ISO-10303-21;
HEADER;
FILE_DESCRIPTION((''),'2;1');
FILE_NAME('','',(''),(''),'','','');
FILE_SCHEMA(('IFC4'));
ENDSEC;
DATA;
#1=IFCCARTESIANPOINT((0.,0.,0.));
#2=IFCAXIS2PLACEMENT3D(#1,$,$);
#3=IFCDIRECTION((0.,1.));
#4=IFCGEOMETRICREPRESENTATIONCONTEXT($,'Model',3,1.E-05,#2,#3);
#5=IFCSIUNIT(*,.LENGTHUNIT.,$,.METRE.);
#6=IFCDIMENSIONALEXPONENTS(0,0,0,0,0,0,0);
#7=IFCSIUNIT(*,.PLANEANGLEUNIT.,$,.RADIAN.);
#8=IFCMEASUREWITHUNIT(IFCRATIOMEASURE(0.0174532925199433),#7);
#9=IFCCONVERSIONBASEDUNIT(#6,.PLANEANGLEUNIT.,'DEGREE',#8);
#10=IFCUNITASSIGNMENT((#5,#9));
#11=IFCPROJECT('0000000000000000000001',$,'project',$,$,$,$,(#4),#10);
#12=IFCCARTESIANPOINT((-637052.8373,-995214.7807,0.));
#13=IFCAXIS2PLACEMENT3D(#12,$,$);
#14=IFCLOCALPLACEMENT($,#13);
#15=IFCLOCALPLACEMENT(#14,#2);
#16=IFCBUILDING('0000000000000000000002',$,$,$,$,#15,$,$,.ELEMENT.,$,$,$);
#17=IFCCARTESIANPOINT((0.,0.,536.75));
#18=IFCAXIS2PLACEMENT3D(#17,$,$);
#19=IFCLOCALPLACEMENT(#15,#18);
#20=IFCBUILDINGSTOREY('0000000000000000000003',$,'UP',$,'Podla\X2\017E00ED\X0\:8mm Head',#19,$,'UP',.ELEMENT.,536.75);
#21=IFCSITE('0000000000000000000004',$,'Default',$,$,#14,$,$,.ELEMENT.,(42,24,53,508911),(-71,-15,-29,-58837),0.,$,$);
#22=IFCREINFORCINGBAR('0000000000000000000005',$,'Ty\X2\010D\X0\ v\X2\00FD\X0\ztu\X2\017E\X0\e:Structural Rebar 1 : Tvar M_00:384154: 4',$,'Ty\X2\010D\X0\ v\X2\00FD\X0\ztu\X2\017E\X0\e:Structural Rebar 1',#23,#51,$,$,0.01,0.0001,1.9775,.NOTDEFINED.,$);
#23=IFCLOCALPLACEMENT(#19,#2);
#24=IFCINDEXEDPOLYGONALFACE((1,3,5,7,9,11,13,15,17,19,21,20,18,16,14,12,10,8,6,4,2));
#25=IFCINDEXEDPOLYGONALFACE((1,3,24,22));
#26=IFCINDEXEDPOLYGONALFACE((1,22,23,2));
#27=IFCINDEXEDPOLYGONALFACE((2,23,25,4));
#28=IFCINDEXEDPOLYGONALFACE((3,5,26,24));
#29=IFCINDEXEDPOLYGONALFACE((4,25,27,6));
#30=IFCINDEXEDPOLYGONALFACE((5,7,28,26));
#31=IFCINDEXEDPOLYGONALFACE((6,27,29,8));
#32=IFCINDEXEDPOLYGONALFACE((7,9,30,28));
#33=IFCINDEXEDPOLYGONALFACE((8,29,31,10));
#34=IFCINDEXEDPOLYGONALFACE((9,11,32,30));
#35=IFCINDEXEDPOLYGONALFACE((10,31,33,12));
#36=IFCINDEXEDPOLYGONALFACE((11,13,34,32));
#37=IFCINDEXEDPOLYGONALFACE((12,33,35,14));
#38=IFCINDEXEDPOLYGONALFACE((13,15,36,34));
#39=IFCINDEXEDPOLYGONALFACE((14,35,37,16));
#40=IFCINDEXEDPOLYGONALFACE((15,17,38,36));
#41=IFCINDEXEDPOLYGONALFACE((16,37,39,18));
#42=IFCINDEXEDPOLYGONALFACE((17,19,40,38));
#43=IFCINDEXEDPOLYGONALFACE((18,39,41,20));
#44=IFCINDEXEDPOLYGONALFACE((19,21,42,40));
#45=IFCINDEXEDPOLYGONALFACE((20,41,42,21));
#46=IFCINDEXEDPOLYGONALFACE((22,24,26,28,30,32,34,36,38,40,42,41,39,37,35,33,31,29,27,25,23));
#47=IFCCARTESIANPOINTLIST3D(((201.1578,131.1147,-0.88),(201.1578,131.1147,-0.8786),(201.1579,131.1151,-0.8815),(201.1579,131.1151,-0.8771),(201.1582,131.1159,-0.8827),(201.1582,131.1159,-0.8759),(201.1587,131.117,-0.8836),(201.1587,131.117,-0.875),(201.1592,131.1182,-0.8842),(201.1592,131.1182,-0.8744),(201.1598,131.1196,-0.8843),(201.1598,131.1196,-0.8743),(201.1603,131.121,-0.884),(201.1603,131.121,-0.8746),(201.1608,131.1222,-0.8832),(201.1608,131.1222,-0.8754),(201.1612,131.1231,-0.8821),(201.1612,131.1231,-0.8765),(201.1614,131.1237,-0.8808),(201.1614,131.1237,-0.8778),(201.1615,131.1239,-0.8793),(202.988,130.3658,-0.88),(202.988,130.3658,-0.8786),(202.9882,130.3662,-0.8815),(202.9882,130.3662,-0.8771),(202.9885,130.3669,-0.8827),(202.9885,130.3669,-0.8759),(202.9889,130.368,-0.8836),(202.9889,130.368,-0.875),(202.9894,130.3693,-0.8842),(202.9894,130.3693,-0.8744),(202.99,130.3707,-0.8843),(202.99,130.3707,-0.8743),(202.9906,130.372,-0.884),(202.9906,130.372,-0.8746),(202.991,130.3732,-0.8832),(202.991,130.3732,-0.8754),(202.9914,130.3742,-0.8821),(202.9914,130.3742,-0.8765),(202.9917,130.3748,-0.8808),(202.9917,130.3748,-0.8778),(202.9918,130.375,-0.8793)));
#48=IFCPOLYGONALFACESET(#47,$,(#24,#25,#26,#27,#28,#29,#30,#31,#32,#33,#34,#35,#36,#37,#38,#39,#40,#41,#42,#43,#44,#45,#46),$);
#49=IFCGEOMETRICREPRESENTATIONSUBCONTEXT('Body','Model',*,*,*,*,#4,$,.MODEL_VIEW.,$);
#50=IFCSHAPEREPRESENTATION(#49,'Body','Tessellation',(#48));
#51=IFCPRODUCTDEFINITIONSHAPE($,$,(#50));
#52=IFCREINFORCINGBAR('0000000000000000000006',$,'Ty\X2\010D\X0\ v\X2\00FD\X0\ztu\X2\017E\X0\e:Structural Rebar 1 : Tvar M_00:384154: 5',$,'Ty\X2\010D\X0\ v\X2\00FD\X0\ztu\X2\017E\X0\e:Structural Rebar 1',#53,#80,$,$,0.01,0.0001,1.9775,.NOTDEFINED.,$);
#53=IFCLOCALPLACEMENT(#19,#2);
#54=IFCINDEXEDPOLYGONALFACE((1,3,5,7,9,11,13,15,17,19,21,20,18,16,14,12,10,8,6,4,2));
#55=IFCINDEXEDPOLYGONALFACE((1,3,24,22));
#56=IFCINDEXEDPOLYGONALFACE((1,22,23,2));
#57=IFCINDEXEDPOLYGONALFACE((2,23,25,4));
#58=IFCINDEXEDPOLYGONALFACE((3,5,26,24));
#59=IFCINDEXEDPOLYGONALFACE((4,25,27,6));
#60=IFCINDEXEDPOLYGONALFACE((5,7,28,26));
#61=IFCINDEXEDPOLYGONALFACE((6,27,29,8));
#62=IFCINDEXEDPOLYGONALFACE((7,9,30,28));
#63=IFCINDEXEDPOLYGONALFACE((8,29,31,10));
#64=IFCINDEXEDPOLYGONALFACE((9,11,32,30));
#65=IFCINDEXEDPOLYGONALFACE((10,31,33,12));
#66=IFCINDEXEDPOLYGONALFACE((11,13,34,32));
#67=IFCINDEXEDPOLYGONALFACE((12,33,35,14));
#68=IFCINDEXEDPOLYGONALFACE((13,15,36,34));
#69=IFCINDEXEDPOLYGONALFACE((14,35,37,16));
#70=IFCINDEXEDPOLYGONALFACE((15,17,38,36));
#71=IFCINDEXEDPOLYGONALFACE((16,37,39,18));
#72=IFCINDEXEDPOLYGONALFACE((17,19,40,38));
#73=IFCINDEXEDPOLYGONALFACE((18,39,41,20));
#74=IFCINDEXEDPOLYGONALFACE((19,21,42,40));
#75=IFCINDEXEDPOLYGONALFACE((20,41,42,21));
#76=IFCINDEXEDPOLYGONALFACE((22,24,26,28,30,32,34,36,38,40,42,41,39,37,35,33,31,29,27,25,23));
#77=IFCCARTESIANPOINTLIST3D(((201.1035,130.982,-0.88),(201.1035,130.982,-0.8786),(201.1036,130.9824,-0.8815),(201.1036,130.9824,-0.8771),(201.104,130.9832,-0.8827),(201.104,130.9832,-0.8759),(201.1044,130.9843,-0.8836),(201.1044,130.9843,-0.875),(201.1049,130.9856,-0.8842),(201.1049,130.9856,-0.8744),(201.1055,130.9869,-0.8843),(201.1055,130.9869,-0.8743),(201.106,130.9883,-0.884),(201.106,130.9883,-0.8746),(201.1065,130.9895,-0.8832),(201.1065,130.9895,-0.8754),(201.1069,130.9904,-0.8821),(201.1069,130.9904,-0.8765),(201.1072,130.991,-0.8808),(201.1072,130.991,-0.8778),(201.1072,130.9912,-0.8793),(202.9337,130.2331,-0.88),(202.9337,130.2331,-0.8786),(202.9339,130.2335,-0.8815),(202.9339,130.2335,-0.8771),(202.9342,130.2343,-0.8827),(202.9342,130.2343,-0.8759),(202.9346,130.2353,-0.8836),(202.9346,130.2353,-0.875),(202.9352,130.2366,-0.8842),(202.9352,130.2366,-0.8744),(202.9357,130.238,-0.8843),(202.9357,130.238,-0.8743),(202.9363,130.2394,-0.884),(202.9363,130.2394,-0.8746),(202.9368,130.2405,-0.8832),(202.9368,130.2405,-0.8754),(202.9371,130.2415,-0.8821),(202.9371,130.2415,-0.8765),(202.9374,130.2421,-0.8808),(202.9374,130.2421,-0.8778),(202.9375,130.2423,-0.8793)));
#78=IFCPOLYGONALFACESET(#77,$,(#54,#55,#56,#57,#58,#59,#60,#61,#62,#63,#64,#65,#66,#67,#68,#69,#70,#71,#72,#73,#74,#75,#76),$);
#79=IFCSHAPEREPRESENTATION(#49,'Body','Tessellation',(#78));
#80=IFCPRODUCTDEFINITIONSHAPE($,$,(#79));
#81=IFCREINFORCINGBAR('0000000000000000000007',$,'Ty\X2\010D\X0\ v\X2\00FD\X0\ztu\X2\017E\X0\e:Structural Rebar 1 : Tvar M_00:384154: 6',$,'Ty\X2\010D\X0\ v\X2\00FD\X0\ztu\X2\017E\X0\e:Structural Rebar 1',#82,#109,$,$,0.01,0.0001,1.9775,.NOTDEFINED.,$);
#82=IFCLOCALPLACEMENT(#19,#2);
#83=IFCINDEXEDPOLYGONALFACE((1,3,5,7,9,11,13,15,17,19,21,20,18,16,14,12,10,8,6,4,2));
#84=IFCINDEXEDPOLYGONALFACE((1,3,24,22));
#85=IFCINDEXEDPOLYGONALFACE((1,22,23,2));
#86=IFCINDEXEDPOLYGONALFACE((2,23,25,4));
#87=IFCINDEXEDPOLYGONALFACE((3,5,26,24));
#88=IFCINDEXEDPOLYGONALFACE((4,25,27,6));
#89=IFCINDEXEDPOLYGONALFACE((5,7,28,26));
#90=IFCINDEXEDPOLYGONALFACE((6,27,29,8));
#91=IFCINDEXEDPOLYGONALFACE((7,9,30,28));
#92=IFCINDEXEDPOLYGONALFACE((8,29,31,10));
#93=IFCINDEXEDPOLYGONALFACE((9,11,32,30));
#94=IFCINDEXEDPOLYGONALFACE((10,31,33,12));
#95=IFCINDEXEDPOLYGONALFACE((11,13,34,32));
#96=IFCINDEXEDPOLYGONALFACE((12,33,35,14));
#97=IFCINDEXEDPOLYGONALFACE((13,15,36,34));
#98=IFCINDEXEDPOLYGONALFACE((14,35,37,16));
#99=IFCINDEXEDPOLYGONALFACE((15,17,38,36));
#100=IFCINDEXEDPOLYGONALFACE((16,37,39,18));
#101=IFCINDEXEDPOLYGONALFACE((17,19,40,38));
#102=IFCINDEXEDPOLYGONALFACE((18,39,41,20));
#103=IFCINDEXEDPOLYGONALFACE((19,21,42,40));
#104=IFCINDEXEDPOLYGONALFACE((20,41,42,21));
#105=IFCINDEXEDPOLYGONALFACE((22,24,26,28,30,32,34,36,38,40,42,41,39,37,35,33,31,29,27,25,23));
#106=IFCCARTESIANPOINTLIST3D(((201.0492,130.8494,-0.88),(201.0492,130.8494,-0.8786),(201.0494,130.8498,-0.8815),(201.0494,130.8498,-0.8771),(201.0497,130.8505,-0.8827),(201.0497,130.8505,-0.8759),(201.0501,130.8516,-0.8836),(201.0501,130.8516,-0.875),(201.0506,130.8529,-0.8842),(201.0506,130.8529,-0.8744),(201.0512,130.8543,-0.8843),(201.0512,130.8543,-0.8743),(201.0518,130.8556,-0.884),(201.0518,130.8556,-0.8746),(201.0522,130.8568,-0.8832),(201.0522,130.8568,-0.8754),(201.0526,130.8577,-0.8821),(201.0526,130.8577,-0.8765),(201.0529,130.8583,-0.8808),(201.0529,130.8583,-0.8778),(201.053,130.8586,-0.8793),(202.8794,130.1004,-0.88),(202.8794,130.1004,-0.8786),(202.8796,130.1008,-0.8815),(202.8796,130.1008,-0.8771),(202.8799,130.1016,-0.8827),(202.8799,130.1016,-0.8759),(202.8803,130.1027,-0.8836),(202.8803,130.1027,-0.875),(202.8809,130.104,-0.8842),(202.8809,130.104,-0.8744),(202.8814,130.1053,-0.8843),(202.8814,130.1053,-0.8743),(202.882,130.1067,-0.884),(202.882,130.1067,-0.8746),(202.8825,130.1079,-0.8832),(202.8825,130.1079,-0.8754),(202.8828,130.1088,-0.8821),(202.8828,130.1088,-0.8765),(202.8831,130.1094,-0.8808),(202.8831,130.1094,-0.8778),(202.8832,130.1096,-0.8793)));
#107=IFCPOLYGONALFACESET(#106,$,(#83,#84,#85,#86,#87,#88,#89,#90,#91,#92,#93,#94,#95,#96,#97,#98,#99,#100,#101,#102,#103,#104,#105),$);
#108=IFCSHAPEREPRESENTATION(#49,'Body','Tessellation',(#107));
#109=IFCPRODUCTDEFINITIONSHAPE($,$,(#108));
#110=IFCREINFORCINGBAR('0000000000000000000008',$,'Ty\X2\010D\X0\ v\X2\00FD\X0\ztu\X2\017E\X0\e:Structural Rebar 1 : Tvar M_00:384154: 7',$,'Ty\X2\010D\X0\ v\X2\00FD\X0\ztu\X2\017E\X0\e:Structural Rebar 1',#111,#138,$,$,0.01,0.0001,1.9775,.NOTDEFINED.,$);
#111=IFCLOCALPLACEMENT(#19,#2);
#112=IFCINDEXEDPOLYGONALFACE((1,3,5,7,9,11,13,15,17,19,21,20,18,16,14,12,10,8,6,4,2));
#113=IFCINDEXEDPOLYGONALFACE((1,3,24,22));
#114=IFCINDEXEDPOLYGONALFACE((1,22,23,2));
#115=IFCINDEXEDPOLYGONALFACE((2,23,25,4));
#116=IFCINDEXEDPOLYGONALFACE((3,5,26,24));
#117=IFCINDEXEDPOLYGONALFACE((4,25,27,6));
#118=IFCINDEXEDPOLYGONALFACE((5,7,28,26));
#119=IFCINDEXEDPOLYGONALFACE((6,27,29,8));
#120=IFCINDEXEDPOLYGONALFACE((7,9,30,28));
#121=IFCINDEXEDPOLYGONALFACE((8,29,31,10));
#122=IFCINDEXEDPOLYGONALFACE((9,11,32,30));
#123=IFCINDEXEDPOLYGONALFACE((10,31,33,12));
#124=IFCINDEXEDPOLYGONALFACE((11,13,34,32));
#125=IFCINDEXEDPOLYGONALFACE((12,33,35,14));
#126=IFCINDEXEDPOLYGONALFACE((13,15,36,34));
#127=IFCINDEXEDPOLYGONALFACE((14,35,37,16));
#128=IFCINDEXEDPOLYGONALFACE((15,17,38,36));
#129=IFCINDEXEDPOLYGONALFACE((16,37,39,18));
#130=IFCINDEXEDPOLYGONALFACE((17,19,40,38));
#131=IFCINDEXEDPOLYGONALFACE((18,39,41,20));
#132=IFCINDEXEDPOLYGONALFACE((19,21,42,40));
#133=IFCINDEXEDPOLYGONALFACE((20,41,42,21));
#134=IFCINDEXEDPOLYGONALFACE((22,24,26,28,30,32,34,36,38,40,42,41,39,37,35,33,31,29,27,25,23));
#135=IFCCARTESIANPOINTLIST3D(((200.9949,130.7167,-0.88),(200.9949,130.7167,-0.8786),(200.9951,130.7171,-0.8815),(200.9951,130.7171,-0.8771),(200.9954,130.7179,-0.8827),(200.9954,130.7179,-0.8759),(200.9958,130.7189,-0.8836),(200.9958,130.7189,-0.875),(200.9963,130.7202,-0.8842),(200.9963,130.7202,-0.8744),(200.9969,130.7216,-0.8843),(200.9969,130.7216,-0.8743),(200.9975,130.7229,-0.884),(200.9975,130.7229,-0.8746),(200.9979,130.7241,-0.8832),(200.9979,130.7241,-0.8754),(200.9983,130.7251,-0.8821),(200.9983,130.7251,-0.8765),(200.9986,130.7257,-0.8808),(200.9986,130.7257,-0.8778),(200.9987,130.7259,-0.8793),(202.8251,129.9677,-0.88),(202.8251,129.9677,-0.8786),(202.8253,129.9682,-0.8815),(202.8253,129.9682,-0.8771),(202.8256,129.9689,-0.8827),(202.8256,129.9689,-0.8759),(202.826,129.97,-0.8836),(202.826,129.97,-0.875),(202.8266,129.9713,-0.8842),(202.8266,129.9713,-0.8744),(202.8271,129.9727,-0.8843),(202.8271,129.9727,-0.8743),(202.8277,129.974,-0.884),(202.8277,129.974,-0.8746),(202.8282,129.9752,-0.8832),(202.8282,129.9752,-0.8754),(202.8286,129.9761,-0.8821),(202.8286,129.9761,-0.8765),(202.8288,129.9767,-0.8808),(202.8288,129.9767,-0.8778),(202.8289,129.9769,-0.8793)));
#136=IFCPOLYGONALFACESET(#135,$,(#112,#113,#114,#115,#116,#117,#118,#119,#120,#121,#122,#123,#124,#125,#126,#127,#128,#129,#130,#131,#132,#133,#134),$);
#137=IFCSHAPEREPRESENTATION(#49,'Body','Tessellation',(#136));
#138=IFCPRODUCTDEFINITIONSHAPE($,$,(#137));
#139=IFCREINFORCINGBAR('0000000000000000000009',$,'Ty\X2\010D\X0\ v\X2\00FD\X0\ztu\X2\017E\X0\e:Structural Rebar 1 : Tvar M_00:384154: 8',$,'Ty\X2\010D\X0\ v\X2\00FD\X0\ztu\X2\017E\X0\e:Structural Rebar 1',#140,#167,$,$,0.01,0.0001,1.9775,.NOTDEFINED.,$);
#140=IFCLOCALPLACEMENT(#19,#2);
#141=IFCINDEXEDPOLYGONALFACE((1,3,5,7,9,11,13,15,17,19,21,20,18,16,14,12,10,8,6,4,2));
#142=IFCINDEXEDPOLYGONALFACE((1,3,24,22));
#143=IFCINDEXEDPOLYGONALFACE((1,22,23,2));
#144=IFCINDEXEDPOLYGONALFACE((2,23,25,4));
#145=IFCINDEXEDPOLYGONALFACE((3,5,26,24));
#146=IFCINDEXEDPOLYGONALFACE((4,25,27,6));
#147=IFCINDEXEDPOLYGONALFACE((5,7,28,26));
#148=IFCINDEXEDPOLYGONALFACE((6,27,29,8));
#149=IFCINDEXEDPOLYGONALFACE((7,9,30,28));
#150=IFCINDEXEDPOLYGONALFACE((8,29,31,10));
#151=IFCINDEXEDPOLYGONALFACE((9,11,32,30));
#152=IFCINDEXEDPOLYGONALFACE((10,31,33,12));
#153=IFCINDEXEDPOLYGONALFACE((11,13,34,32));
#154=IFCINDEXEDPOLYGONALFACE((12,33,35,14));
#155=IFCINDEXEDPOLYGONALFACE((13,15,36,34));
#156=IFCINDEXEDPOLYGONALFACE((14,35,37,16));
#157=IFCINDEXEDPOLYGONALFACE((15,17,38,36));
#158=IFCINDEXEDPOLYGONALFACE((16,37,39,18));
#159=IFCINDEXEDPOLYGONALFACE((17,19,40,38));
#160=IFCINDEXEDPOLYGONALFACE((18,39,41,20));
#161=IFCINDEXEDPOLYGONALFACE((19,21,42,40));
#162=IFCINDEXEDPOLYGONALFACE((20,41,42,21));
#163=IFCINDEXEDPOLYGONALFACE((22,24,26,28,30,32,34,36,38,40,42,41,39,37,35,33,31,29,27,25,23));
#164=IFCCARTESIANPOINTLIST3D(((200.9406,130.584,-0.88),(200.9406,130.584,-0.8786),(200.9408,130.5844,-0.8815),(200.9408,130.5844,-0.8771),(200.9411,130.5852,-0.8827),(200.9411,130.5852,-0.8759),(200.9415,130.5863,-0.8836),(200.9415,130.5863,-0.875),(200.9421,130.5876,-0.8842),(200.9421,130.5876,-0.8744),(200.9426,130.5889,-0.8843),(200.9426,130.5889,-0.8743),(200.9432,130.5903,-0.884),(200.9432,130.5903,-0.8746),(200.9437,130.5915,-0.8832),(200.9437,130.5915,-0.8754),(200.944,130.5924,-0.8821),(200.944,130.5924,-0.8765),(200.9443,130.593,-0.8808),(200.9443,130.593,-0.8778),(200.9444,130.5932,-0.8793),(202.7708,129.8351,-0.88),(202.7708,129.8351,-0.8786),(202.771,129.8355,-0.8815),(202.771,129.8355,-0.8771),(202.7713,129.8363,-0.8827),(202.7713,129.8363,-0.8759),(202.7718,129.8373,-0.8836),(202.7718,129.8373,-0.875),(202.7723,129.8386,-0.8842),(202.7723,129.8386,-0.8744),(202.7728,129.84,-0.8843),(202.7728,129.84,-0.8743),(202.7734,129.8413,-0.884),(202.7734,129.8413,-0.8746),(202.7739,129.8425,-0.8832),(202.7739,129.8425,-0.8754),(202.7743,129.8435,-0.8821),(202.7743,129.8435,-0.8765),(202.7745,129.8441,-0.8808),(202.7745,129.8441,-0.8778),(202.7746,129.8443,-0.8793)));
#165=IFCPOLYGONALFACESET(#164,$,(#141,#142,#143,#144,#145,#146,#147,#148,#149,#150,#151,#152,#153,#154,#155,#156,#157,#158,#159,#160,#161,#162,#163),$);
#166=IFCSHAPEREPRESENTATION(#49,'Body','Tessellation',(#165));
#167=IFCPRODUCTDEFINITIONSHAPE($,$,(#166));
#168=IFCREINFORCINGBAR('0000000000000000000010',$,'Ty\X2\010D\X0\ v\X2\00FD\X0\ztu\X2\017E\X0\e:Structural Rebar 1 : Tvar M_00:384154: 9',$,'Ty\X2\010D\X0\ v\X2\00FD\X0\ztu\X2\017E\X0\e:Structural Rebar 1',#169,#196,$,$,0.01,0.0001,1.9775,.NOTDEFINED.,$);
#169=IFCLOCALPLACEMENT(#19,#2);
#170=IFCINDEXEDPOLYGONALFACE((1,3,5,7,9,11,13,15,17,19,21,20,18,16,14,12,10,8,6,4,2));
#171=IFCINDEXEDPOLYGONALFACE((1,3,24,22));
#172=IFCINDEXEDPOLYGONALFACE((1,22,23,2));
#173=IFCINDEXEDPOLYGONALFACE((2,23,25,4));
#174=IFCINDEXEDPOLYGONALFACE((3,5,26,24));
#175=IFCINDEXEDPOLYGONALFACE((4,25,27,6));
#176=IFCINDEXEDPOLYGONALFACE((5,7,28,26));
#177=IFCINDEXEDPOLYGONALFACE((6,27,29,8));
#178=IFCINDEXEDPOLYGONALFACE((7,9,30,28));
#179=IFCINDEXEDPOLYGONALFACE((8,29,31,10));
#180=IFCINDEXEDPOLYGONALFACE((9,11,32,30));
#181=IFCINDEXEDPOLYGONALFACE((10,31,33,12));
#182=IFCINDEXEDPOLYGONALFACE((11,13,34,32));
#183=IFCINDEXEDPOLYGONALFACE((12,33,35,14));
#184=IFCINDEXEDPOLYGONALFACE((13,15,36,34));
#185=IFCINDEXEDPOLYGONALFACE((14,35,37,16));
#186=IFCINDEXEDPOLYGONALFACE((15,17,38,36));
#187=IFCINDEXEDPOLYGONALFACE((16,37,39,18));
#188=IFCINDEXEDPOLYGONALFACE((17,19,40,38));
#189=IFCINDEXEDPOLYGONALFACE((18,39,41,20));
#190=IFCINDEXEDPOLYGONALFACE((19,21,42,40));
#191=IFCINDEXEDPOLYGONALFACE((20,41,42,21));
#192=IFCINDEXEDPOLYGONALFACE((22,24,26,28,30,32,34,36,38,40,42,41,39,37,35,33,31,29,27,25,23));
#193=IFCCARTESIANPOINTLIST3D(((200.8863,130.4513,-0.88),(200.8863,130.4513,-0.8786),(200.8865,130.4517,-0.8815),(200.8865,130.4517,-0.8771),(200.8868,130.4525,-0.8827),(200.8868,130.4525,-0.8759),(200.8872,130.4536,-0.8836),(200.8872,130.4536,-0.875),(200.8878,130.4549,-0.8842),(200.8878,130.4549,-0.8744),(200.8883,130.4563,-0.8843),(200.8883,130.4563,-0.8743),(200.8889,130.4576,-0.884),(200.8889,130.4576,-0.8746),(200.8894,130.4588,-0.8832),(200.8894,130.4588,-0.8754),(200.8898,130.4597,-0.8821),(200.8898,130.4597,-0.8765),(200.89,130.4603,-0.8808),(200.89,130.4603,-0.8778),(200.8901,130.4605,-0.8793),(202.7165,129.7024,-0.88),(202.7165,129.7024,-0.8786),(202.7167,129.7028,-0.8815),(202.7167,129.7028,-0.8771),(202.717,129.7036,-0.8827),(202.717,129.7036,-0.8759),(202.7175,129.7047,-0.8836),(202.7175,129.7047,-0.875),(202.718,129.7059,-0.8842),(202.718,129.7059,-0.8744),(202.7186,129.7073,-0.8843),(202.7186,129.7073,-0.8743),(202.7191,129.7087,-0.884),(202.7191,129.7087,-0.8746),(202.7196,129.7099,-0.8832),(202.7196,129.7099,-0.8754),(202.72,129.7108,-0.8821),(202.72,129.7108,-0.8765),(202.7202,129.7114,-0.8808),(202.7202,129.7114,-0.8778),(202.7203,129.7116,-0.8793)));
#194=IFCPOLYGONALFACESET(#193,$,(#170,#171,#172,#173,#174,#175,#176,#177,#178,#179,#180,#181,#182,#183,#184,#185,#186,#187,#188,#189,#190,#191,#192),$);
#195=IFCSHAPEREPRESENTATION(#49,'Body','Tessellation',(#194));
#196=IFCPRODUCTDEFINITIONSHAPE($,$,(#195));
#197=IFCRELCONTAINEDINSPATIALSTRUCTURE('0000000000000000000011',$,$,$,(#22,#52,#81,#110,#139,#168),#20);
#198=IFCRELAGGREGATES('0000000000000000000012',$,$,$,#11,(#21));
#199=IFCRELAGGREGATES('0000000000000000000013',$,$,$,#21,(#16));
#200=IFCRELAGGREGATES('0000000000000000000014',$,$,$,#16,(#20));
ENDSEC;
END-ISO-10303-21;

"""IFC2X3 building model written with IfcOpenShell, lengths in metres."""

from ifc_helpers import new_model, entity, si_unit, converted_unit, direction, frame, origin, place, context, subcontext, project, spatial, element, save


model = new_model("IFC2X3")

# Units and contexts
model_context = context("Model", 3, precision=1e-05, world=origin(), true_north=direction((0.0, 1.0)))
body_context = subcontext(model_context, "Body", "Model", "MODEL_VIEW")
ifc_project = project(units=[si_unit("LENGTHUNIT", "METRE"), converted_unit("PLANEANGLEUNIT", "DEGREE", entity("IfcRatioMeasure", 0.0174532925199433), si_unit("PLANEANGLEUNIT", "RADIAN"), dimensions=[0, 0, 0, 0, 0, 0, 0])], contexts=[model_context])

# Site, building, storey
site_placement = place(None, frame((-637052.8373, -995214.7807, 0.0)))
site = spatial("IfcSite", under=ifc_project, at=site_placement, Name="Default", CompositionType="ELEMENT", RefLatitude=(42, 24, 53, 508911), RefLongitude=(-71, -15, -29, -58837), RefElevation=0.0)
building_placement = place(site_placement, origin())
building = spatial("IfcBuilding", under=site, at=building_placement, CompositionType="ELEMENT")
storey_placement = place(building_placement, frame((0.0, 0.0, 536.75)))
storey = spatial("IfcBuildingStorey", under=building, at=storey_placement, Name="UP", ObjectType="Podlaží:8mm Head", LongName="UP", CompositionType="ELEMENT", Elevation=536.75)

# Reinforcing bars
reinforcing_bar_1_placement = place(storey_placement, origin())
element("IfcReinforcingBar", 1, at=reinforcing_bar_1_placement, inside=storey, Name="Tyč výztuže:Structural Rebar 1 : Tvar M_00:384154: 4", ObjectType="Tyč výztuže:Structural Rebar 1", BarLength=1.9775, BarRole="NOTDEFINED", CrossSectionArea=0.0001, NominalDiameter=0.01, context=body_context, shape_type="AdvancedSweptSolid", body=[
    entity("IfcSweptDiskSolid", entity("IfcCompositeCurve", [entity("IfcCompositeCurveSegment", "CONTINUOUS", True, entity("IfcPolyline", [entity("IfcCartesianPoint", [-202.9899, -130.3703, 0.8793]), entity("IfcCartesianPoint", [-201.1596, -131.1193, 0.8793])]))], False), 0.005, None, 0.0, 1.0),
])
reinforcing_bar_2_placement = place(storey_placement, origin())
element("IfcReinforcingBar", 2, at=reinforcing_bar_2_placement, inside=storey, Name="Tyč výztuže:Structural Rebar 1 : Tvar M_00:384154: 5", ObjectType="Tyč výztuže:Structural Rebar 1", BarLength=1.9775, BarRole="NOTDEFINED", CrossSectionArea=0.0001, NominalDiameter=0.01, context=body_context, shape_type="AdvancedSweptSolid", body=[
    entity("IfcSweptDiskSolid", entity("IfcCompositeCurve", [entity("IfcCompositeCurveSegment", "CONTINUOUS", True, entity("IfcPolyline", [entity("IfcCartesianPoint", [-202.9356, -130.2377, 0.8793]), entity("IfcCartesianPoint", [-201.1053, -130.9866, 0.8793])]))], False), 0.005, None, 0.0, 1.0),
])
reinforcing_bar_3_placement = place(storey_placement, origin())
element("IfcReinforcingBar", 3, at=reinforcing_bar_3_placement, inside=storey, Name="Tyč výztuže:Structural Rebar 1 : Tvar M_00:384154: 6", ObjectType="Tyč výztuže:Structural Rebar 1", BarLength=1.9775, BarRole="NOTDEFINED", CrossSectionArea=0.0001, NominalDiameter=0.01, context=body_context, shape_type="AdvancedSweptSolid", body=[
    entity("IfcSweptDiskSolid", entity("IfcCompositeCurve", [entity("IfcCompositeCurveSegment", "CONTINUOUS", True, entity("IfcPolyline", [entity("IfcCartesianPoint", [-202.8813, -130.105, 0.8793]), entity("IfcCartesianPoint", [-201.0511, -130.8539, 0.8793])]))], False), 0.005, None, 0.0, 1.0),
])
reinforcing_bar_4_placement = place(storey_placement, origin())
element("IfcReinforcingBar", 4, at=reinforcing_bar_4_placement, inside=storey, Name="Tyč výztuže:Structural Rebar 1 : Tvar M_00:384154: 7", ObjectType="Tyč výztuže:Structural Rebar 1", BarLength=1.9775, BarRole="NOTDEFINED", CrossSectionArea=0.0001, NominalDiameter=0.01, context=body_context, shape_type="AdvancedSweptSolid", body=[
    entity("IfcSweptDiskSolid", entity("IfcCompositeCurve", [entity("IfcCompositeCurveSegment", "CONTINUOUS", True, entity("IfcPolyline", [entity("IfcCartesianPoint", [-202.827, -129.9723, 0.8793]), entity("IfcCartesianPoint", [-200.9968, -130.7213, 0.8793])]))], False), 0.005, None, 0.0, 1.0),
])
reinforcing_bar_5_placement = place(storey_placement, origin())
element("IfcReinforcingBar", 5, at=reinforcing_bar_5_placement, inside=storey, Name="Tyč výztuže:Structural Rebar 1 : Tvar M_00:384154: 8", ObjectType="Tyč výztuže:Structural Rebar 1", BarLength=1.9775, BarRole="NOTDEFINED", CrossSectionArea=0.0001, NominalDiameter=0.01, context=body_context, shape_type="AdvancedSweptSolid", body=[
    entity("IfcSweptDiskSolid", entity("IfcCompositeCurve", [entity("IfcCompositeCurveSegment", "CONTINUOUS", True, entity("IfcPolyline", [entity("IfcCartesianPoint", [-202.7727, -129.8396, 0.8793]), entity("IfcCartesianPoint", [-200.9425, -130.5886, 0.8793])]))], False), 0.005, None, 0.0, 1.0),
])
reinforcing_bar_6_placement = place(storey_placement, origin())
element("IfcReinforcingBar", 6, at=reinforcing_bar_6_placement, inside=storey, Name="Tyč výztuže:Structural Rebar 1 : Tvar M_00:384154: 9", ObjectType="Tyč výztuže:Structural Rebar 1", BarLength=1.9775, BarRole="NOTDEFINED", CrossSectionArea=0.0001, NominalDiameter=0.01, context=body_context, shape_type="AdvancedSweptSolid", body=[
    entity("IfcSweptDiskSolid", entity("IfcCompositeCurve", [entity("IfcCompositeCurveSegment", "CONTINUOUS", True, entity("IfcPolyline", [entity("IfcCartesianPoint", [-202.7184, -129.707, 0.8793]), entity("IfcCartesianPoint", [-200.8882, -130.4559, 0.8793])]))], False), 0.005, None, 0.0, 1.0),
])

save(model, "model.ifc")
